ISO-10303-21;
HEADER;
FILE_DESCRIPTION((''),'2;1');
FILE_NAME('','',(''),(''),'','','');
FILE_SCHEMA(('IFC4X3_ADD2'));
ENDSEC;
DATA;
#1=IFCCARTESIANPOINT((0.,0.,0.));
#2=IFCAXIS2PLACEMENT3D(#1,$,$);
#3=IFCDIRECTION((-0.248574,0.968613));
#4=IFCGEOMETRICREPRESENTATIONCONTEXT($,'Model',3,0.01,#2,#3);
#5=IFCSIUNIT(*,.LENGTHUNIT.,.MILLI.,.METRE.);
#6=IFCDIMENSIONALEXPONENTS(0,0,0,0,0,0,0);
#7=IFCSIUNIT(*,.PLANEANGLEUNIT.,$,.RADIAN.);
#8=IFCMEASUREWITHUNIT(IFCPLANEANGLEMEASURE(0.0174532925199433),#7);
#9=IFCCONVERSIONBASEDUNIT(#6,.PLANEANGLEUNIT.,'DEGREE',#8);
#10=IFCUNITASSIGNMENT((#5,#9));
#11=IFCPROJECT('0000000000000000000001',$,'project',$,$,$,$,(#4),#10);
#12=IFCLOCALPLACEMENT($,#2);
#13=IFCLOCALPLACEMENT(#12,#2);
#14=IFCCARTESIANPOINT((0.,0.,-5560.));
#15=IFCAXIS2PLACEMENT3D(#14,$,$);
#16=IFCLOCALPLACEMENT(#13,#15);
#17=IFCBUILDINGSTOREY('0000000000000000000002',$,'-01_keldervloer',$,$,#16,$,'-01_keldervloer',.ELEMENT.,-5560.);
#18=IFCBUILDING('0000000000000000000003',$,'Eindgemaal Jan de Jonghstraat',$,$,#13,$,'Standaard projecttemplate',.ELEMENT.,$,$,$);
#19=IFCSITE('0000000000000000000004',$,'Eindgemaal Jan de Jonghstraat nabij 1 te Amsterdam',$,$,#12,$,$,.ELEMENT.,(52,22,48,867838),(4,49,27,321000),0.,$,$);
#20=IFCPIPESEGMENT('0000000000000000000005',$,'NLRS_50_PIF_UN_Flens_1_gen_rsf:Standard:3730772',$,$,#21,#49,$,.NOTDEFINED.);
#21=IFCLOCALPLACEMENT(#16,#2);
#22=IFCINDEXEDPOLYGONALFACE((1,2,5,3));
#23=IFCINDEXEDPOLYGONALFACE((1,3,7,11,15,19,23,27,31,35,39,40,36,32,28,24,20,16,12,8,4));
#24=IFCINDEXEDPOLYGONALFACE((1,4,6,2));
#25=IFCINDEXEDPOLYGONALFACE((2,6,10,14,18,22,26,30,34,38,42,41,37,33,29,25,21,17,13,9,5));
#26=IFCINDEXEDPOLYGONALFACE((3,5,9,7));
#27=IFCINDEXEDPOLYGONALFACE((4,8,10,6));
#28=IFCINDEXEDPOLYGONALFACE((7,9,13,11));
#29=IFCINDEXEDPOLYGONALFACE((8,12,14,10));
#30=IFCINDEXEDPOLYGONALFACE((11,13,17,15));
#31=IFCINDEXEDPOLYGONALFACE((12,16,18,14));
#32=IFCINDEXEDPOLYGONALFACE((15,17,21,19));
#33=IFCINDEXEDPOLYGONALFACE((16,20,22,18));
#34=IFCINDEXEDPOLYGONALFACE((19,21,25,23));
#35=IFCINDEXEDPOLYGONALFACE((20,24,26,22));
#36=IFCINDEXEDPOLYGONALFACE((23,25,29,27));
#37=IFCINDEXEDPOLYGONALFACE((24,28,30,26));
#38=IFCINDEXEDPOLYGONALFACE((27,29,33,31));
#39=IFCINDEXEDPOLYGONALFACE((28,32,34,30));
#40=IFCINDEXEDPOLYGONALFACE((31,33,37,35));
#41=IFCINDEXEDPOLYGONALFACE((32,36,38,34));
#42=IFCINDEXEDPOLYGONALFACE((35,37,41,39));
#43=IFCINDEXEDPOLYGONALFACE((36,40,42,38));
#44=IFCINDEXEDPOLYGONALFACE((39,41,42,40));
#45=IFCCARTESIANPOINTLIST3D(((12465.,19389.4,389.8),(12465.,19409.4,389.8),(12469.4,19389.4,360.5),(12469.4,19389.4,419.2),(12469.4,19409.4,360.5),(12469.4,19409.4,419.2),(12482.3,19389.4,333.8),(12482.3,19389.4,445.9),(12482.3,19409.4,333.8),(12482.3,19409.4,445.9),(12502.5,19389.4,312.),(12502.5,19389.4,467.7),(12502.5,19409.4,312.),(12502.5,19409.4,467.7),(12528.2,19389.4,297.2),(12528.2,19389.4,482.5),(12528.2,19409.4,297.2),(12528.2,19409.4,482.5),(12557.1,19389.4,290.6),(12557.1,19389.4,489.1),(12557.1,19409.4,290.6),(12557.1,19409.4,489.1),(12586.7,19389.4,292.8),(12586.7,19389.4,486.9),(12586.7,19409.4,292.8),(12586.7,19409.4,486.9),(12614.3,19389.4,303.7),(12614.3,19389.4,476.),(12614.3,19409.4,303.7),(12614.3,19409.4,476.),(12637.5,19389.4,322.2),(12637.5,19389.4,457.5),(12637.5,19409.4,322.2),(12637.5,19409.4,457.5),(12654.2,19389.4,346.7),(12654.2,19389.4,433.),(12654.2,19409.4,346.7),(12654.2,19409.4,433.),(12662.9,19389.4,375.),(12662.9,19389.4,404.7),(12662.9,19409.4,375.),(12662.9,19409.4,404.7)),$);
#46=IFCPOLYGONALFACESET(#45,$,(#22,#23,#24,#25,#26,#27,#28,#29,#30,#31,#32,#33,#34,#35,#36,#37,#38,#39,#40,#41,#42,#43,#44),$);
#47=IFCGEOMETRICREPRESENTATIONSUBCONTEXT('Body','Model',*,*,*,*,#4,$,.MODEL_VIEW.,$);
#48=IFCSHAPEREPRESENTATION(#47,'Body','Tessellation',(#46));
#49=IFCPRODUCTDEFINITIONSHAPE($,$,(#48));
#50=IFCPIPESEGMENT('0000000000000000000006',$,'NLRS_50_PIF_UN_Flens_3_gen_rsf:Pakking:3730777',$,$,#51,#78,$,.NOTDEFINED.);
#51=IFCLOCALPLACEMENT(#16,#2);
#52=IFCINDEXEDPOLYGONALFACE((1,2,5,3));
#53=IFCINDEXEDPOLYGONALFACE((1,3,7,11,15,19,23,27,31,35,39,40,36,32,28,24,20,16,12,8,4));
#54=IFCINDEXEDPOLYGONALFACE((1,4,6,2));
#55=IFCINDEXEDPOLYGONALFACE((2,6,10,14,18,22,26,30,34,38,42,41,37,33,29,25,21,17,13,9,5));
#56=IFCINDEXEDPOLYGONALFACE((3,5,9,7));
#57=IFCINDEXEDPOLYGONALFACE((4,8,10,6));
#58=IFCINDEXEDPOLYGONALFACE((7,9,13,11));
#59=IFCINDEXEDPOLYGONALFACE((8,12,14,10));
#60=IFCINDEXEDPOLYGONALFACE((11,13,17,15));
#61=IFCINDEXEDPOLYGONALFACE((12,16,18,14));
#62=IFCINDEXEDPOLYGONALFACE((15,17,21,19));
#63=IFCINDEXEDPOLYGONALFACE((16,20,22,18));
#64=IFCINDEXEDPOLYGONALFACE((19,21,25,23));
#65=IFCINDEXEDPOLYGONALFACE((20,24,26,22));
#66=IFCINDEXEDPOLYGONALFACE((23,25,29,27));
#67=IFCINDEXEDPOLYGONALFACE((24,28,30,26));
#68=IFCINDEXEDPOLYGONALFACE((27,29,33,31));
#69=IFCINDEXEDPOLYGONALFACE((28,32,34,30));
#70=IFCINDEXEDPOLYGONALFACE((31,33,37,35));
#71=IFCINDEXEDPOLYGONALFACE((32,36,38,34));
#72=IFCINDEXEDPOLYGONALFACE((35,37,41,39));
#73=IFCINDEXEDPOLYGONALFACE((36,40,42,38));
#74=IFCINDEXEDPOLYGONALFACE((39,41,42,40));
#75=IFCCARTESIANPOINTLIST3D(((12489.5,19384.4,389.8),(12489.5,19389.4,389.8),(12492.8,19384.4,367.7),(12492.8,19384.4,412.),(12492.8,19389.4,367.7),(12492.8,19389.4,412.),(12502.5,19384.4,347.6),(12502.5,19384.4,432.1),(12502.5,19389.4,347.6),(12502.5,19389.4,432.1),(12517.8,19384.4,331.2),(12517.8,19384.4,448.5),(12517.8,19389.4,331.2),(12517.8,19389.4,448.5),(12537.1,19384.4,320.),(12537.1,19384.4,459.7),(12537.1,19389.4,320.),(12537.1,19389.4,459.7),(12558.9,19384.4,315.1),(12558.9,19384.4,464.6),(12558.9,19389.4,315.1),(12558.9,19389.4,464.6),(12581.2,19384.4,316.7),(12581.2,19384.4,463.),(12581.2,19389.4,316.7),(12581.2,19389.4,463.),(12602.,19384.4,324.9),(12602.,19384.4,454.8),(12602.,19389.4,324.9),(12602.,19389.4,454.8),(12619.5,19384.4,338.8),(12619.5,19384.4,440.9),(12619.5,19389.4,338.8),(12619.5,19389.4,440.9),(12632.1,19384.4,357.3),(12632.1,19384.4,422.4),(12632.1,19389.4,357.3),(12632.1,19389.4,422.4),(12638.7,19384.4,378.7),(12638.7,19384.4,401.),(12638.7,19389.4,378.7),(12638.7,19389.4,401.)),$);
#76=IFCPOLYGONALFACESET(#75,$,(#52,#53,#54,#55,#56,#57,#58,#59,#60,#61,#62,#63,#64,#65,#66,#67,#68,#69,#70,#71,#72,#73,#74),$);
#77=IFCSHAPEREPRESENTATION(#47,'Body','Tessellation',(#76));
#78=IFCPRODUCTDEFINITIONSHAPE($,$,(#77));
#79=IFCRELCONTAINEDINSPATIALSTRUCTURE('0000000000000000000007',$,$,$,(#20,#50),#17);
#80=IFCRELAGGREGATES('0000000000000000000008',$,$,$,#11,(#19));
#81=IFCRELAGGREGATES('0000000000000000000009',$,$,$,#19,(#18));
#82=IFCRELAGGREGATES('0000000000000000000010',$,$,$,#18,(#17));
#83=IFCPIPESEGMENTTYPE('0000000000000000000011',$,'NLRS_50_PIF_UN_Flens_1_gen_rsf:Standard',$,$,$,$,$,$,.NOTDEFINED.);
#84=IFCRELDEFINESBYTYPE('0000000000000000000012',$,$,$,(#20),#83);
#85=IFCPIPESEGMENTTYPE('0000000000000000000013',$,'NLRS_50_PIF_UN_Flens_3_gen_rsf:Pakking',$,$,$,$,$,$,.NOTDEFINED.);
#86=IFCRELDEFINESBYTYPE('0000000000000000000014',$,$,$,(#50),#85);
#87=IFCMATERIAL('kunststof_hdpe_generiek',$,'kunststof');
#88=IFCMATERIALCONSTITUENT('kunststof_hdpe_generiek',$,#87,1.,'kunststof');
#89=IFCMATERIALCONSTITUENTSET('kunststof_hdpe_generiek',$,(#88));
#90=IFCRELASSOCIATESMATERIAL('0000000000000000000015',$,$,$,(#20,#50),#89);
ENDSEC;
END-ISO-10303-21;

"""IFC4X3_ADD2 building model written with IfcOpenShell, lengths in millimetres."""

from ifc_helpers import new_model, entity, si_unit, converted_unit, direction, frame, frame_2d, origin, place, context, subcontext, project, spatial, circle, extrude, source, transform, mapped, material, constituent, constituent_set, type_object, type_shapes, element, save


model = new_model("IFC4X3_ADD2")

# Units and contexts
model_context = context("Model", 3, precision=0.01, world=origin(), true_north=direction((-0.248574, 0.968613)))
body_context = subcontext(model_context, "Body", "Model", "MODEL_VIEW")
ifc_project = project(units=[si_unit("LENGTHUNIT", "METRE", prefix="MILLI"), converted_unit("PLANEANGLEUNIT", "DEGREE", entity("IfcPlaneAngleMeasure", 0.0174532925199433), si_unit("PLANEANGLEUNIT", "RADIAN"), dimensions=[0, 0, 0, 0, 0, 0, 0])], contexts=[model_context])

# Site, building, storey
site_placement = place(None, origin())
site = spatial("IfcSite", under=ifc_project, at=site_placement, Name="Eindgemaal Jan de Jonghstraat nabij 1 te Amsterdam", CompositionType="ELEMENT", RefLatitude=(52, 22, 48, 867838), RefLongitude=(4, 49, 27, 321000), RefElevation=0.0)
building_placement = place(site_placement, origin())
building = spatial("IfcBuilding", under=site, at=building_placement, Name="Eindgemaal Jan de Jonghstraat", LongName="Standaard projecttemplate", CompositionType="ELEMENT")
storey_placement = place(building_placement, frame((0.0, 0.0, -5560.0)))
storey = spatial("IfcBuildingStorey", under=building, at=storey_placement, Name="-01_keldervloer", LongName="-01_keldervloer", CompositionType="ELEMENT", Elevation=-5560.0)

# Pipe segments
ifc_material_1 = material(Name="kunststof_hdpe_generiek", Category="kunststof")
ifc_constituent_1 = constituent(ifc_material_1, Name="kunststof_hdpe_generiek", Category="kunststof", fraction=1.0)
ifc_constituent_set_1 = constituent_set(constituents=[ifc_constituent_1], Name="kunststof_hdpe_generiek")
pipe_segment_type_1 = type_object("IfcPipeSegmentType", Name="NLRS_50_PIF_UN_Flens_1_gen_rsf:Standard", PredefinedType="NOTDEFINED")
shared_shape_1 = source(origin(), body_context, "Body", "SweptSolid", [
    extrude(circle(Radius=99.5, at=frame_2d((0.0, 0.0), x_axis=(1.0, 0.0))), frame((-10.0, 0.0, 0.0), z_axis=(1.0, 0.0, 0.0), x_axis=(0.0, 1.0, 0.0)), (0.0, 0.0, 1.0), 20.0),
])
type_shapes(pipe_segment_type_1, [shared_shape_1])
pipe_segment_1_placement = place(storey_placement, frame((12564.5, 19399.4, 389.8), z_axis=(0.0, 0.0, 1.0), x_axis=(0.0, 1.0, 0.0)))
element("IfcPipeSegment", 1, at=pipe_segment_1_placement, inside=storey, type_object=pipe_segment_type_1, material=ifc_constituent_set_1, Name="NLRS_50_PIF_UN_Flens_1_gen_rsf:Standard:3730772", PredefinedType="NOTDEFINED", context=body_context, shape_type="MappedRepresentation", body=[
    mapped(shared_shape_1, transform((0.0, 0.0, 0.0), scale=1.0)),
])
pipe_segment_type_2 = type_object("IfcPipeSegmentType", Name="NLRS_50_PIF_UN_Flens_3_gen_rsf:Pakking", PredefinedType="NOTDEFINED")
shared_shape_2 = source(origin(), body_context, "Body", "SweptSolid", [
    extrude(circle(Radius=75.0, at=frame_2d((0.0, 0.0), x_axis=(1.0, 0.0))), frame((0.0, 0.0, 0.0), z_axis=(0.0, 0.0, 1.0), x_axis=(0.0, -1.0, 0.0)), (0.0, 0.0, 1.0), 5.0),
])
type_shapes(pipe_segment_type_2, [shared_shape_2])
pipe_segment_2_placement = place(storey_placement, frame((12564.5, 19384.4, 389.8), z_axis=(0.0, 1.0, 0.0), x_axis=(0.0, 0.0, 1.0)))
element("IfcPipeSegment", 2, at=pipe_segment_2_placement, inside=storey, type_object=pipe_segment_type_2, material=ifc_constituent_set_1, Name="NLRS_50_PIF_UN_Flens_3_gen_rsf:Pakking:3730777", PredefinedType="NOTDEFINED", context=body_context, shape_type="MappedRepresentation", body=[
    mapped(shared_shape_2, transform((0.0, 0.0, 0.0), scale=1.0)),
])

save(model, "model.ifc")
